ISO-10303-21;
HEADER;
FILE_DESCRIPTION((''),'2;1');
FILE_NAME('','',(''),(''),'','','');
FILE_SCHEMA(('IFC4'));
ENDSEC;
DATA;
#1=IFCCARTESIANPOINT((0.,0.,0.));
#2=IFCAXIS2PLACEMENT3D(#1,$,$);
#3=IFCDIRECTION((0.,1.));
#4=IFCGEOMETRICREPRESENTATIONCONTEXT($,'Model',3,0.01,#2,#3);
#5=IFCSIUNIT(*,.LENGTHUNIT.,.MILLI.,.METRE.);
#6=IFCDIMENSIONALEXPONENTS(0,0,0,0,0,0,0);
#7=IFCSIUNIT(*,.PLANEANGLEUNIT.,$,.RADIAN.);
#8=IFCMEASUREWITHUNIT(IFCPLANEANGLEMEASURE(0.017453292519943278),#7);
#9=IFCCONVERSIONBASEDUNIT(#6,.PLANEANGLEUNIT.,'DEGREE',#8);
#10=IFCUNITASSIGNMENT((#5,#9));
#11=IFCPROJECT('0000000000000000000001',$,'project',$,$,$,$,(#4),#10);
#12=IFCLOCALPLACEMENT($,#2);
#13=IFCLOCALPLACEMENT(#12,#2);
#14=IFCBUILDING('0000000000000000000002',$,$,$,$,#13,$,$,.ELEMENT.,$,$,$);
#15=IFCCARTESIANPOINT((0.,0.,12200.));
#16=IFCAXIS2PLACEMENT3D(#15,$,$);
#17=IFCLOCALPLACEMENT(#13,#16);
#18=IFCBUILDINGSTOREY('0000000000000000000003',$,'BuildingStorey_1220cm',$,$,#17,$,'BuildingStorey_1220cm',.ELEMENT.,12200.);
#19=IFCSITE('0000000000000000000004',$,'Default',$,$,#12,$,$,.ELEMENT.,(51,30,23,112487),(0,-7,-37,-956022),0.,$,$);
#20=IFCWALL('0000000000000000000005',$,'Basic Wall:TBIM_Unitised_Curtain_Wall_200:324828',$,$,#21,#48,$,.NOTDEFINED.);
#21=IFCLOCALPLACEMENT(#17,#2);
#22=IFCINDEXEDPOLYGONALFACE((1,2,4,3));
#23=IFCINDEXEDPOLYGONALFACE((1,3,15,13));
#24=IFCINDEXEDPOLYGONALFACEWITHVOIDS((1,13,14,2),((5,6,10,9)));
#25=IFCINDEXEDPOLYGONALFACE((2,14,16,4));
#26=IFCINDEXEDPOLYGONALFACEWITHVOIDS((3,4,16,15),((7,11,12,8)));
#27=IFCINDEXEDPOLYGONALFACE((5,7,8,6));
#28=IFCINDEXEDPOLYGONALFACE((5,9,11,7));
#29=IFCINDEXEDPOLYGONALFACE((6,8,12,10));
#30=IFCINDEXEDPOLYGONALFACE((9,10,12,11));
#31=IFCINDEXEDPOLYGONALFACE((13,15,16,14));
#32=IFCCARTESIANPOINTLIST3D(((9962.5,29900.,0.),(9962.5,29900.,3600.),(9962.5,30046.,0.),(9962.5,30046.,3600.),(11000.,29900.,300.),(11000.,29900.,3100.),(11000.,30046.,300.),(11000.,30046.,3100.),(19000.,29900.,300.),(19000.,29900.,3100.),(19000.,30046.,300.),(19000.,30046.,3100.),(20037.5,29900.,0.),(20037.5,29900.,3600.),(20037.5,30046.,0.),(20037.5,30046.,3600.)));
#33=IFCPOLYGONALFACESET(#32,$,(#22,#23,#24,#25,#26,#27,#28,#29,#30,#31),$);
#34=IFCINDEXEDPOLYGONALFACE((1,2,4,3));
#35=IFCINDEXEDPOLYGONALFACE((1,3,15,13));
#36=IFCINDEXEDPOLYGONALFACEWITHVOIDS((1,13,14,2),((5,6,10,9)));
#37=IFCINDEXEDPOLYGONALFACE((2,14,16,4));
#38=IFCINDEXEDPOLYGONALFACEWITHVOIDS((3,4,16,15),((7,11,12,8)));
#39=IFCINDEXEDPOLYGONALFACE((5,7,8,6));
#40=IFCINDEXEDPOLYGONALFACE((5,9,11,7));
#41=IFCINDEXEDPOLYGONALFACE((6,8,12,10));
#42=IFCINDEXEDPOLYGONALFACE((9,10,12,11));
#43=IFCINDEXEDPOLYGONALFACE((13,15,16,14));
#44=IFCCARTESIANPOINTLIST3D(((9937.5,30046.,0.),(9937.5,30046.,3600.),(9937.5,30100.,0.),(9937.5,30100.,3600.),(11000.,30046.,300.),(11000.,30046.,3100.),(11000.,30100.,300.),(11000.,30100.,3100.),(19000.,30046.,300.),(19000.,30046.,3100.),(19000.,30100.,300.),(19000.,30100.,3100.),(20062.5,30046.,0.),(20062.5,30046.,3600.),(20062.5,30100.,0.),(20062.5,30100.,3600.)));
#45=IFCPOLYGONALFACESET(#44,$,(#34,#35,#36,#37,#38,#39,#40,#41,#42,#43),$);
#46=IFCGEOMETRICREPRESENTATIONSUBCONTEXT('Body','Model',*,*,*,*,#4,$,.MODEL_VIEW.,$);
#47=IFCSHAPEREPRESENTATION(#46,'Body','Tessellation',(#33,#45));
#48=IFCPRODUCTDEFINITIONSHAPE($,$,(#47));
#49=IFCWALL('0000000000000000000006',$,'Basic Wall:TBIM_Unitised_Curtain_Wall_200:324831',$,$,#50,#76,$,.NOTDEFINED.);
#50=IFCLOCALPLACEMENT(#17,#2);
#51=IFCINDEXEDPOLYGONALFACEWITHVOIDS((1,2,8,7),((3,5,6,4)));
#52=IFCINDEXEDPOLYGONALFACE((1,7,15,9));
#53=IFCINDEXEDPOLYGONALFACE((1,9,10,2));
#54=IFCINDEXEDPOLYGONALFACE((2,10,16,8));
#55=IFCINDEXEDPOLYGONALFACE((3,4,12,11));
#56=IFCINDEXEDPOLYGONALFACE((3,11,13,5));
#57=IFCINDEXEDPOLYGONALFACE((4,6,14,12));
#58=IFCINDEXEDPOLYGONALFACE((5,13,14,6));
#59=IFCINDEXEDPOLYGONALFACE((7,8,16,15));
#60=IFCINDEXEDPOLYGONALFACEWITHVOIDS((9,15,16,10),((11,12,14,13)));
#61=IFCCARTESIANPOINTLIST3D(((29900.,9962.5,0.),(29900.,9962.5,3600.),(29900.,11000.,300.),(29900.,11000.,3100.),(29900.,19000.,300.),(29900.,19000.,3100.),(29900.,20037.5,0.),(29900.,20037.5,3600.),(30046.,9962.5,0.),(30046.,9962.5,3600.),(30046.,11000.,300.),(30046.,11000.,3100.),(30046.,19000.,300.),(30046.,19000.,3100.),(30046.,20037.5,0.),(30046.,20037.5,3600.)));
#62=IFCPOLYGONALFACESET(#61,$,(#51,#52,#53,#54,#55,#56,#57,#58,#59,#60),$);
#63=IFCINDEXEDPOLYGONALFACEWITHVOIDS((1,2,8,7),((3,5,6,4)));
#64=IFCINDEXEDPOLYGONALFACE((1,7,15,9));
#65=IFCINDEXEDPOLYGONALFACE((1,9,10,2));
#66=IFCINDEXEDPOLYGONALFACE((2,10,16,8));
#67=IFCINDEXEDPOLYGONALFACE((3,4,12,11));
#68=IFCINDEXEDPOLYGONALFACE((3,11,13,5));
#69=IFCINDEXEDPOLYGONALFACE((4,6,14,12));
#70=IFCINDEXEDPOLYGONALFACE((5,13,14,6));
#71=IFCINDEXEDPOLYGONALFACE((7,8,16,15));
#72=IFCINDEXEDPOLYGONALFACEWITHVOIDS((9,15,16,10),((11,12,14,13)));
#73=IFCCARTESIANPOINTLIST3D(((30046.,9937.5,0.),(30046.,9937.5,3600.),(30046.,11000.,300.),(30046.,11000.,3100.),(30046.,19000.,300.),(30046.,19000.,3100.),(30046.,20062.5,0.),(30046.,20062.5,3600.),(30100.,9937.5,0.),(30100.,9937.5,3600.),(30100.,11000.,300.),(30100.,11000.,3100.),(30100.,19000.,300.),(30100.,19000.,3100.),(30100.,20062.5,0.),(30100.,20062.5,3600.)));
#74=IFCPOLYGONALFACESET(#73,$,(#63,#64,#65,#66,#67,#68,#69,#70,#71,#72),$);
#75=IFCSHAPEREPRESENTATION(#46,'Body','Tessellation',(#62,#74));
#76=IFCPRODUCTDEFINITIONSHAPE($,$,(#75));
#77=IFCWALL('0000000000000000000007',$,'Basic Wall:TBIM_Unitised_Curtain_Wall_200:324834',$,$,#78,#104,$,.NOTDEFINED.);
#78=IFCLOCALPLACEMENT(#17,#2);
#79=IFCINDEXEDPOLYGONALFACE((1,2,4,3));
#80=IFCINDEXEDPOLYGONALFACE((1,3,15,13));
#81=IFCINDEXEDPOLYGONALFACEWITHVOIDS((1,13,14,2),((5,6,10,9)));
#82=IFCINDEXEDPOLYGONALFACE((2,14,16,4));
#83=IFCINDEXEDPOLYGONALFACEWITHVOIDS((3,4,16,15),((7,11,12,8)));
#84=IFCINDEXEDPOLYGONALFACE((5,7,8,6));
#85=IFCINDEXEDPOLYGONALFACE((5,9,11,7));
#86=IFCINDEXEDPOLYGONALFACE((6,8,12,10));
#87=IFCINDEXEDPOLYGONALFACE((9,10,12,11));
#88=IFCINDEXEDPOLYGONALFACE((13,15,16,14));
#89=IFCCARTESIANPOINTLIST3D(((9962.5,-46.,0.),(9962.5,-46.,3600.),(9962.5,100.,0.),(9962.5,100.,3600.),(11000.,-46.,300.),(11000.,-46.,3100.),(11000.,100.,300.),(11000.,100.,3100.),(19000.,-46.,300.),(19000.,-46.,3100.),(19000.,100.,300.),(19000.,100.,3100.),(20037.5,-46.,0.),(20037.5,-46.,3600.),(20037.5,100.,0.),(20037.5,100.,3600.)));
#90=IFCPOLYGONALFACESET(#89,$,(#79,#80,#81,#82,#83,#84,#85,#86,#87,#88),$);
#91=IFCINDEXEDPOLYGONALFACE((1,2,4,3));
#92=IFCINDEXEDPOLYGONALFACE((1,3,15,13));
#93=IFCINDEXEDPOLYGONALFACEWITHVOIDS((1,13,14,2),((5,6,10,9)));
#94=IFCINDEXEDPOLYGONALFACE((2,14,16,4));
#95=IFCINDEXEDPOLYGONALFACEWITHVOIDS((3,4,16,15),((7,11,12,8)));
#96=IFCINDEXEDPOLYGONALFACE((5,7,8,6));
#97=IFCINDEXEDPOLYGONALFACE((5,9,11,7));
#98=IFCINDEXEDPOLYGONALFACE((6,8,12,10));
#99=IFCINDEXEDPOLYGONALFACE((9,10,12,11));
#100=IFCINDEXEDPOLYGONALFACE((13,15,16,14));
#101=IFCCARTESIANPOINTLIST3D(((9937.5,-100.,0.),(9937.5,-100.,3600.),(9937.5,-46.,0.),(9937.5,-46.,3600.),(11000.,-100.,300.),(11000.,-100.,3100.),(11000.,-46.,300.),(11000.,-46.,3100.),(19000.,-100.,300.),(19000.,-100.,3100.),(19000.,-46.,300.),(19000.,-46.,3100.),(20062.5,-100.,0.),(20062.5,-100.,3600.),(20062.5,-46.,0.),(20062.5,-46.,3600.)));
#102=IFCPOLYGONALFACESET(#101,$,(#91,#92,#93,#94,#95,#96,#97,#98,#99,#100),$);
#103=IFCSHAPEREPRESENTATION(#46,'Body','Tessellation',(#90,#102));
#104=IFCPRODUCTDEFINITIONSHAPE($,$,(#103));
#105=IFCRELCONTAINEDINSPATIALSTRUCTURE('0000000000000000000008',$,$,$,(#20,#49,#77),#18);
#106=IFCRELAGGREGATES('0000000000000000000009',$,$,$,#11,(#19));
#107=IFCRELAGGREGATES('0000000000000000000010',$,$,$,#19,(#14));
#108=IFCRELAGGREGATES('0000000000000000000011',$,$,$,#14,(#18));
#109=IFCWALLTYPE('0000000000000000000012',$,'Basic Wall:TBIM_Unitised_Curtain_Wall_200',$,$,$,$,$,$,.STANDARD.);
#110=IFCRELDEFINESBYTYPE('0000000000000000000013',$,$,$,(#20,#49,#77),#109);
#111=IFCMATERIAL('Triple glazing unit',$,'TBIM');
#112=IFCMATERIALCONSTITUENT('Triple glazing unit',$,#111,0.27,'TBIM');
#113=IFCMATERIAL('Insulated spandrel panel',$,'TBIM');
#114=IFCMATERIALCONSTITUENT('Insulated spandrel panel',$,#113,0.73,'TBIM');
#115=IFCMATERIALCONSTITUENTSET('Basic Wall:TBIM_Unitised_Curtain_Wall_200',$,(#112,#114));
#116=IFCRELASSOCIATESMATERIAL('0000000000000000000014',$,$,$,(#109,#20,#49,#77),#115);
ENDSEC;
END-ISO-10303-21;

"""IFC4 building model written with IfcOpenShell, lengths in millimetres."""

from ifc_helpers import new_model, entity, si_unit, converted_unit, direction, frame, origin, place, context, subcontext, project, spatial, indexed_curve, outline, extrude, material, constituent, constituent_set, type_object, element, save


model = new_model("IFC4")

# Units and contexts
model_context = context("Model", 3, precision=0.01, world=origin(), true_north=direction((0.0, 1.0)))
body_context = subcontext(model_context, "Body", "Model", "MODEL_VIEW")
ifc_project = project(units=[si_unit("LENGTHUNIT", "METRE", prefix="MILLI"), converted_unit("PLANEANGLEUNIT", "DEGREE", entity("IfcPlaneAngleMeasure", 0.017453292519943278), si_unit("PLANEANGLEUNIT", "RADIAN"), dimensions=[0, 0, 0, 0, 0, 0, 0])], contexts=[model_context])

# Site, building, storey
site_placement = place(None, origin())
site = spatial("IfcSite", under=ifc_project, at=site_placement, Name="Default", CompositionType="ELEMENT", RefLatitude=(51, 30, 23, 112487), RefLongitude=(0, -7, -37, -956022), RefElevation=0.0)
building_placement = place(site_placement, origin())
building = spatial("IfcBuilding", under=site, at=building_placement, CompositionType="ELEMENT")
storey_placement = place(building_placement, frame((0.0, 0.0, 12200.0)))
storey = spatial("IfcBuildingStorey", under=building, at=storey_placement, Name="BuildingStorey_1220cm", LongName="BuildingStorey_1220cm", CompositionType="ELEMENT", Elevation=12200.0)

# Walls, openings
ifc_material_1 = material(Name="Triple glazing unit", Category="TBIM")
ifc_constituent_1 = constituent(ifc_material_1, Name="Triple glazing unit", Category="TBIM", fraction=0.27)
ifc_material_2 = material(Name="Insulated spandrel panel", Category="TBIM")
ifc_constituent_2 = constituent(ifc_material_2, Name="Insulated spandrel panel", Category="TBIM", fraction=0.73)
ifc_constituent_set_1 = constituent_set(constituents=[ifc_constituent_1, ifc_constituent_2], Name="Basic Wall:TBIM_Unitised_Curtain_Wall_200")
wall_type_1 = type_object("IfcWallType", Name="Basic Wall:TBIM_Unitised_Curtain_Wall_200", PredefinedType="STANDARD", material=ifc_constituent_set_1)
wall_1_placement = place(storey_placement, frame((9937.5, 30000.0, 0.0)))
wall_1 = element("IfcWall", 1, at=wall_1_placement, inside=storey, type_object=wall_type_1, material=ifc_constituent_set_1, Name="Basic Wall:TBIM_Unitised_Curtain_Wall_200:324828", PredefinedType="NOTDEFINED", context=body_context, shape_type="SweptSolid", body=[
    extrude(outline(indexed_curve([(-1800.0, -5037.5), (1800.0, -5037.5), (1800.0, -4937.5), (1800.0, 4937.5), (1800.0, 5037.5), (-1800.0, 5037.5), (-1800.0, 4937.5), (-1800.0, -4937.5), (-1800.0, -5037.5)], self_intersect=False), holes=[indexed_curve([(1300.0, -4000.0), (-1500.0, -4000.0), (-1500.0, 4000.0), (1300.0, 4000.0), (1300.0, -4000.0)], self_intersect=False)]), frame((5062.5, -100.0, 1800.0), z_axis=(0.0, 1.0, 0.0), x_axis=(0.0, 0.0, 1.0)), (0.0, 0.0, 1.0), 146.0),
    extrude(outline(indexed_curve([(-1800.0, -5062.5), (1800.0, -5062.5), (1800.0, 5062.5), (-1800.0, 5062.5), (-1800.0, -5062.5)], self_intersect=False), holes=[indexed_curve([(-1500.0, -4000.0), (-1500.0, 4000.0), (1300.0, 4000.0), (1300.0, -4000.0), (-1500.0, -4000.0)], self_intersect=False)]), frame((5062.5, 46.0, 1800.0), z_axis=(0.0, 1.0, 0.0), x_axis=(0.0, 0.0, 1.0)), (0.0, 0.0, 1.0), 54.0),
])
opening_1_placement = place(wall_1_placement, frame((1062.5, -100.0, 300.0)))
element("IfcOpeningElement", 2, at=opening_1_placement, cuts=wall_1, PredefinedType="OPENING", context=body_context, shape_type="SweptSolid", body=[
    extrude(outline(indexed_curve([(2800.0, 0.0), (2800.0, 8000.0), (0.0, 8000.0), (0.0, 0.0), (2800.0, 0.0)], self_intersect=False)), frame((0.0, 0.0, 0.0), z_axis=(0.0, 1.0, 0.0), x_axis=(0.0, 0.0, 1.0)), (0.0, 0.0, 1.0), 200.0),
])
wall_2_placement = place(storey_placement, frame((30000.0, 9937.5, 0.0), z_axis=(0.0, 0.0, 1.0), x_axis=(0.0, 1.0, 0.0)))
wall_2 = element("IfcWall", 3, at=wall_2_placement, inside=storey, type_object=wall_type_1, material=ifc_constituent_set_1, Name="Basic Wall:TBIM_Unitised_Curtain_Wall_200:324831", PredefinedType="NOTDEFINED", context=body_context, shape_type="SweptSolid", body=[
    extrude(outline(indexed_curve([(-5037.5, -1800.0), (-4937.5, -1800.0), (4937.5, -1800.0), (5037.5, -1800.0), (5037.5, 1800.0), (4937.5, 1800.0), (-4937.5, 1800.0), (-5037.5, 1800.0), (-5037.5, -1800.0)], self_intersect=False), holes=[indexed_curve([(-4000.0, 1300.0), (4000.0, 1300.0), (4000.0, -1500.0), (-4000.0, -1500.0), (-4000.0, 1300.0)], self_intersect=False)]), frame((5062.5, 100.0, 1800.0), z_axis=(0.0, -1.0, 0.0), x_axis=(1.0, 0.0, 0.0)), (0.0, 0.0, 1.0), 146.0),
    extrude(outline(indexed_curve([(-1800.0, -5062.5), (1800.0, -5062.5), (1800.0, 5062.5), (-1800.0, 5062.5), (-1800.0, -5062.5)], self_intersect=False), holes=[indexed_curve([(1300.0, 4000.0), (1300.0, -4000.0), (-1500.0, -4000.0), (-1500.0, 4000.0), (1300.0, 4000.0)], self_intersect=False)]), frame((5062.5, -46.0, 1800.0), z_axis=(0.0, -1.0, 0.0), x_axis=(0.0, 0.0, 1.0)), (0.0, 0.0, 1.0), 54.0),
])
opening_2_placement = place(wall_2_placement, frame((1062.5, -100.0, 300.0)))
element("IfcOpeningElement", 4, at=opening_2_placement, cuts=wall_2, PredefinedType="OPENING", context=body_context, shape_type="SweptSolid", body=[
    extrude(outline(indexed_curve([(2800.0, 0.0), (2800.0, 8000.0), (0.0, 8000.0), (0.0, 0.0), (2800.0, 0.0)], self_intersect=False)), frame((0.0, 0.0, 0.0), z_axis=(0.0, 1.0, 0.0), x_axis=(0.0, 0.0, 1.0)), (0.0, 0.0, 1.0), 200.0),
])
wall_3_placement = place(storey_placement, frame((9937.5, 0.0, 0.0)))
wall_3 = element("IfcWall", 5, at=wall_3_placement, inside=storey, type_object=wall_type_1, material=ifc_constituent_set_1, Name="Basic Wall:TBIM_Unitised_Curtain_Wall_200:324834", PredefinedType="NOTDEFINED", context=body_context, shape_type="SweptSolid", body=[
    extrude(outline(indexed_curve([(-1800.0, -5037.5), (1800.0, -5037.5), (1800.0, 5037.5), (-1800.0, 5037.5), (-1800.0, -5037.5)], self_intersect=False), holes=[indexed_curve([(-1500.0, -4000.0), (-1500.0, 4000.0), (1300.0, 4000.0), (1300.0, -4000.0), (-1500.0, -4000.0)], self_intersect=False)]), frame((5062.5, -46.0, 1800.0), z_axis=(0.0, 1.0, 0.0), x_axis=(0.0, 0.0, 1.0)), (0.0, 0.0, 1.0), 146.0),
    extrude(outline(indexed_curve([(-1800.0, -5062.5), (1800.0, -5062.5), (1800.0, 5062.5), (-1800.0, 5062.5), (-1800.0, -5062.5)], self_intersect=False), holes=[indexed_curve([(1300.0, -4000.0), (-1500.0, -4000.0), (-1500.0, 4000.0), (1300.0, 4000.0), (1300.0, -4000.0)], self_intersect=False)]), frame((5062.5, -100.0, 1800.0), z_axis=(0.0, 1.0, 0.0), x_axis=(0.0, 0.0, 1.0)), (0.0, 0.0, 1.0), 54.0),
])
opening_3_placement = place(wall_3_placement, frame((1062.5, -100.0, 300.0)))
element("IfcOpeningElement", 6, at=opening_3_placement, cuts=wall_3, PredefinedType="OPENING", context=body_context, shape_type="SweptSolid", body=[
    extrude(outline(indexed_curve([(2800.0, 0.0), (2800.0, 8000.0), (0.0, 8000.0), (0.0, 0.0), (2800.0, 0.0)], self_intersect=False)), frame((0.0, 0.0, 0.0), z_axis=(0.0, 1.0, 0.0), x_axis=(0.0, 0.0, 1.0)), (0.0, 0.0, 1.0), 200.0),
])

save(model, "model.ifc")
